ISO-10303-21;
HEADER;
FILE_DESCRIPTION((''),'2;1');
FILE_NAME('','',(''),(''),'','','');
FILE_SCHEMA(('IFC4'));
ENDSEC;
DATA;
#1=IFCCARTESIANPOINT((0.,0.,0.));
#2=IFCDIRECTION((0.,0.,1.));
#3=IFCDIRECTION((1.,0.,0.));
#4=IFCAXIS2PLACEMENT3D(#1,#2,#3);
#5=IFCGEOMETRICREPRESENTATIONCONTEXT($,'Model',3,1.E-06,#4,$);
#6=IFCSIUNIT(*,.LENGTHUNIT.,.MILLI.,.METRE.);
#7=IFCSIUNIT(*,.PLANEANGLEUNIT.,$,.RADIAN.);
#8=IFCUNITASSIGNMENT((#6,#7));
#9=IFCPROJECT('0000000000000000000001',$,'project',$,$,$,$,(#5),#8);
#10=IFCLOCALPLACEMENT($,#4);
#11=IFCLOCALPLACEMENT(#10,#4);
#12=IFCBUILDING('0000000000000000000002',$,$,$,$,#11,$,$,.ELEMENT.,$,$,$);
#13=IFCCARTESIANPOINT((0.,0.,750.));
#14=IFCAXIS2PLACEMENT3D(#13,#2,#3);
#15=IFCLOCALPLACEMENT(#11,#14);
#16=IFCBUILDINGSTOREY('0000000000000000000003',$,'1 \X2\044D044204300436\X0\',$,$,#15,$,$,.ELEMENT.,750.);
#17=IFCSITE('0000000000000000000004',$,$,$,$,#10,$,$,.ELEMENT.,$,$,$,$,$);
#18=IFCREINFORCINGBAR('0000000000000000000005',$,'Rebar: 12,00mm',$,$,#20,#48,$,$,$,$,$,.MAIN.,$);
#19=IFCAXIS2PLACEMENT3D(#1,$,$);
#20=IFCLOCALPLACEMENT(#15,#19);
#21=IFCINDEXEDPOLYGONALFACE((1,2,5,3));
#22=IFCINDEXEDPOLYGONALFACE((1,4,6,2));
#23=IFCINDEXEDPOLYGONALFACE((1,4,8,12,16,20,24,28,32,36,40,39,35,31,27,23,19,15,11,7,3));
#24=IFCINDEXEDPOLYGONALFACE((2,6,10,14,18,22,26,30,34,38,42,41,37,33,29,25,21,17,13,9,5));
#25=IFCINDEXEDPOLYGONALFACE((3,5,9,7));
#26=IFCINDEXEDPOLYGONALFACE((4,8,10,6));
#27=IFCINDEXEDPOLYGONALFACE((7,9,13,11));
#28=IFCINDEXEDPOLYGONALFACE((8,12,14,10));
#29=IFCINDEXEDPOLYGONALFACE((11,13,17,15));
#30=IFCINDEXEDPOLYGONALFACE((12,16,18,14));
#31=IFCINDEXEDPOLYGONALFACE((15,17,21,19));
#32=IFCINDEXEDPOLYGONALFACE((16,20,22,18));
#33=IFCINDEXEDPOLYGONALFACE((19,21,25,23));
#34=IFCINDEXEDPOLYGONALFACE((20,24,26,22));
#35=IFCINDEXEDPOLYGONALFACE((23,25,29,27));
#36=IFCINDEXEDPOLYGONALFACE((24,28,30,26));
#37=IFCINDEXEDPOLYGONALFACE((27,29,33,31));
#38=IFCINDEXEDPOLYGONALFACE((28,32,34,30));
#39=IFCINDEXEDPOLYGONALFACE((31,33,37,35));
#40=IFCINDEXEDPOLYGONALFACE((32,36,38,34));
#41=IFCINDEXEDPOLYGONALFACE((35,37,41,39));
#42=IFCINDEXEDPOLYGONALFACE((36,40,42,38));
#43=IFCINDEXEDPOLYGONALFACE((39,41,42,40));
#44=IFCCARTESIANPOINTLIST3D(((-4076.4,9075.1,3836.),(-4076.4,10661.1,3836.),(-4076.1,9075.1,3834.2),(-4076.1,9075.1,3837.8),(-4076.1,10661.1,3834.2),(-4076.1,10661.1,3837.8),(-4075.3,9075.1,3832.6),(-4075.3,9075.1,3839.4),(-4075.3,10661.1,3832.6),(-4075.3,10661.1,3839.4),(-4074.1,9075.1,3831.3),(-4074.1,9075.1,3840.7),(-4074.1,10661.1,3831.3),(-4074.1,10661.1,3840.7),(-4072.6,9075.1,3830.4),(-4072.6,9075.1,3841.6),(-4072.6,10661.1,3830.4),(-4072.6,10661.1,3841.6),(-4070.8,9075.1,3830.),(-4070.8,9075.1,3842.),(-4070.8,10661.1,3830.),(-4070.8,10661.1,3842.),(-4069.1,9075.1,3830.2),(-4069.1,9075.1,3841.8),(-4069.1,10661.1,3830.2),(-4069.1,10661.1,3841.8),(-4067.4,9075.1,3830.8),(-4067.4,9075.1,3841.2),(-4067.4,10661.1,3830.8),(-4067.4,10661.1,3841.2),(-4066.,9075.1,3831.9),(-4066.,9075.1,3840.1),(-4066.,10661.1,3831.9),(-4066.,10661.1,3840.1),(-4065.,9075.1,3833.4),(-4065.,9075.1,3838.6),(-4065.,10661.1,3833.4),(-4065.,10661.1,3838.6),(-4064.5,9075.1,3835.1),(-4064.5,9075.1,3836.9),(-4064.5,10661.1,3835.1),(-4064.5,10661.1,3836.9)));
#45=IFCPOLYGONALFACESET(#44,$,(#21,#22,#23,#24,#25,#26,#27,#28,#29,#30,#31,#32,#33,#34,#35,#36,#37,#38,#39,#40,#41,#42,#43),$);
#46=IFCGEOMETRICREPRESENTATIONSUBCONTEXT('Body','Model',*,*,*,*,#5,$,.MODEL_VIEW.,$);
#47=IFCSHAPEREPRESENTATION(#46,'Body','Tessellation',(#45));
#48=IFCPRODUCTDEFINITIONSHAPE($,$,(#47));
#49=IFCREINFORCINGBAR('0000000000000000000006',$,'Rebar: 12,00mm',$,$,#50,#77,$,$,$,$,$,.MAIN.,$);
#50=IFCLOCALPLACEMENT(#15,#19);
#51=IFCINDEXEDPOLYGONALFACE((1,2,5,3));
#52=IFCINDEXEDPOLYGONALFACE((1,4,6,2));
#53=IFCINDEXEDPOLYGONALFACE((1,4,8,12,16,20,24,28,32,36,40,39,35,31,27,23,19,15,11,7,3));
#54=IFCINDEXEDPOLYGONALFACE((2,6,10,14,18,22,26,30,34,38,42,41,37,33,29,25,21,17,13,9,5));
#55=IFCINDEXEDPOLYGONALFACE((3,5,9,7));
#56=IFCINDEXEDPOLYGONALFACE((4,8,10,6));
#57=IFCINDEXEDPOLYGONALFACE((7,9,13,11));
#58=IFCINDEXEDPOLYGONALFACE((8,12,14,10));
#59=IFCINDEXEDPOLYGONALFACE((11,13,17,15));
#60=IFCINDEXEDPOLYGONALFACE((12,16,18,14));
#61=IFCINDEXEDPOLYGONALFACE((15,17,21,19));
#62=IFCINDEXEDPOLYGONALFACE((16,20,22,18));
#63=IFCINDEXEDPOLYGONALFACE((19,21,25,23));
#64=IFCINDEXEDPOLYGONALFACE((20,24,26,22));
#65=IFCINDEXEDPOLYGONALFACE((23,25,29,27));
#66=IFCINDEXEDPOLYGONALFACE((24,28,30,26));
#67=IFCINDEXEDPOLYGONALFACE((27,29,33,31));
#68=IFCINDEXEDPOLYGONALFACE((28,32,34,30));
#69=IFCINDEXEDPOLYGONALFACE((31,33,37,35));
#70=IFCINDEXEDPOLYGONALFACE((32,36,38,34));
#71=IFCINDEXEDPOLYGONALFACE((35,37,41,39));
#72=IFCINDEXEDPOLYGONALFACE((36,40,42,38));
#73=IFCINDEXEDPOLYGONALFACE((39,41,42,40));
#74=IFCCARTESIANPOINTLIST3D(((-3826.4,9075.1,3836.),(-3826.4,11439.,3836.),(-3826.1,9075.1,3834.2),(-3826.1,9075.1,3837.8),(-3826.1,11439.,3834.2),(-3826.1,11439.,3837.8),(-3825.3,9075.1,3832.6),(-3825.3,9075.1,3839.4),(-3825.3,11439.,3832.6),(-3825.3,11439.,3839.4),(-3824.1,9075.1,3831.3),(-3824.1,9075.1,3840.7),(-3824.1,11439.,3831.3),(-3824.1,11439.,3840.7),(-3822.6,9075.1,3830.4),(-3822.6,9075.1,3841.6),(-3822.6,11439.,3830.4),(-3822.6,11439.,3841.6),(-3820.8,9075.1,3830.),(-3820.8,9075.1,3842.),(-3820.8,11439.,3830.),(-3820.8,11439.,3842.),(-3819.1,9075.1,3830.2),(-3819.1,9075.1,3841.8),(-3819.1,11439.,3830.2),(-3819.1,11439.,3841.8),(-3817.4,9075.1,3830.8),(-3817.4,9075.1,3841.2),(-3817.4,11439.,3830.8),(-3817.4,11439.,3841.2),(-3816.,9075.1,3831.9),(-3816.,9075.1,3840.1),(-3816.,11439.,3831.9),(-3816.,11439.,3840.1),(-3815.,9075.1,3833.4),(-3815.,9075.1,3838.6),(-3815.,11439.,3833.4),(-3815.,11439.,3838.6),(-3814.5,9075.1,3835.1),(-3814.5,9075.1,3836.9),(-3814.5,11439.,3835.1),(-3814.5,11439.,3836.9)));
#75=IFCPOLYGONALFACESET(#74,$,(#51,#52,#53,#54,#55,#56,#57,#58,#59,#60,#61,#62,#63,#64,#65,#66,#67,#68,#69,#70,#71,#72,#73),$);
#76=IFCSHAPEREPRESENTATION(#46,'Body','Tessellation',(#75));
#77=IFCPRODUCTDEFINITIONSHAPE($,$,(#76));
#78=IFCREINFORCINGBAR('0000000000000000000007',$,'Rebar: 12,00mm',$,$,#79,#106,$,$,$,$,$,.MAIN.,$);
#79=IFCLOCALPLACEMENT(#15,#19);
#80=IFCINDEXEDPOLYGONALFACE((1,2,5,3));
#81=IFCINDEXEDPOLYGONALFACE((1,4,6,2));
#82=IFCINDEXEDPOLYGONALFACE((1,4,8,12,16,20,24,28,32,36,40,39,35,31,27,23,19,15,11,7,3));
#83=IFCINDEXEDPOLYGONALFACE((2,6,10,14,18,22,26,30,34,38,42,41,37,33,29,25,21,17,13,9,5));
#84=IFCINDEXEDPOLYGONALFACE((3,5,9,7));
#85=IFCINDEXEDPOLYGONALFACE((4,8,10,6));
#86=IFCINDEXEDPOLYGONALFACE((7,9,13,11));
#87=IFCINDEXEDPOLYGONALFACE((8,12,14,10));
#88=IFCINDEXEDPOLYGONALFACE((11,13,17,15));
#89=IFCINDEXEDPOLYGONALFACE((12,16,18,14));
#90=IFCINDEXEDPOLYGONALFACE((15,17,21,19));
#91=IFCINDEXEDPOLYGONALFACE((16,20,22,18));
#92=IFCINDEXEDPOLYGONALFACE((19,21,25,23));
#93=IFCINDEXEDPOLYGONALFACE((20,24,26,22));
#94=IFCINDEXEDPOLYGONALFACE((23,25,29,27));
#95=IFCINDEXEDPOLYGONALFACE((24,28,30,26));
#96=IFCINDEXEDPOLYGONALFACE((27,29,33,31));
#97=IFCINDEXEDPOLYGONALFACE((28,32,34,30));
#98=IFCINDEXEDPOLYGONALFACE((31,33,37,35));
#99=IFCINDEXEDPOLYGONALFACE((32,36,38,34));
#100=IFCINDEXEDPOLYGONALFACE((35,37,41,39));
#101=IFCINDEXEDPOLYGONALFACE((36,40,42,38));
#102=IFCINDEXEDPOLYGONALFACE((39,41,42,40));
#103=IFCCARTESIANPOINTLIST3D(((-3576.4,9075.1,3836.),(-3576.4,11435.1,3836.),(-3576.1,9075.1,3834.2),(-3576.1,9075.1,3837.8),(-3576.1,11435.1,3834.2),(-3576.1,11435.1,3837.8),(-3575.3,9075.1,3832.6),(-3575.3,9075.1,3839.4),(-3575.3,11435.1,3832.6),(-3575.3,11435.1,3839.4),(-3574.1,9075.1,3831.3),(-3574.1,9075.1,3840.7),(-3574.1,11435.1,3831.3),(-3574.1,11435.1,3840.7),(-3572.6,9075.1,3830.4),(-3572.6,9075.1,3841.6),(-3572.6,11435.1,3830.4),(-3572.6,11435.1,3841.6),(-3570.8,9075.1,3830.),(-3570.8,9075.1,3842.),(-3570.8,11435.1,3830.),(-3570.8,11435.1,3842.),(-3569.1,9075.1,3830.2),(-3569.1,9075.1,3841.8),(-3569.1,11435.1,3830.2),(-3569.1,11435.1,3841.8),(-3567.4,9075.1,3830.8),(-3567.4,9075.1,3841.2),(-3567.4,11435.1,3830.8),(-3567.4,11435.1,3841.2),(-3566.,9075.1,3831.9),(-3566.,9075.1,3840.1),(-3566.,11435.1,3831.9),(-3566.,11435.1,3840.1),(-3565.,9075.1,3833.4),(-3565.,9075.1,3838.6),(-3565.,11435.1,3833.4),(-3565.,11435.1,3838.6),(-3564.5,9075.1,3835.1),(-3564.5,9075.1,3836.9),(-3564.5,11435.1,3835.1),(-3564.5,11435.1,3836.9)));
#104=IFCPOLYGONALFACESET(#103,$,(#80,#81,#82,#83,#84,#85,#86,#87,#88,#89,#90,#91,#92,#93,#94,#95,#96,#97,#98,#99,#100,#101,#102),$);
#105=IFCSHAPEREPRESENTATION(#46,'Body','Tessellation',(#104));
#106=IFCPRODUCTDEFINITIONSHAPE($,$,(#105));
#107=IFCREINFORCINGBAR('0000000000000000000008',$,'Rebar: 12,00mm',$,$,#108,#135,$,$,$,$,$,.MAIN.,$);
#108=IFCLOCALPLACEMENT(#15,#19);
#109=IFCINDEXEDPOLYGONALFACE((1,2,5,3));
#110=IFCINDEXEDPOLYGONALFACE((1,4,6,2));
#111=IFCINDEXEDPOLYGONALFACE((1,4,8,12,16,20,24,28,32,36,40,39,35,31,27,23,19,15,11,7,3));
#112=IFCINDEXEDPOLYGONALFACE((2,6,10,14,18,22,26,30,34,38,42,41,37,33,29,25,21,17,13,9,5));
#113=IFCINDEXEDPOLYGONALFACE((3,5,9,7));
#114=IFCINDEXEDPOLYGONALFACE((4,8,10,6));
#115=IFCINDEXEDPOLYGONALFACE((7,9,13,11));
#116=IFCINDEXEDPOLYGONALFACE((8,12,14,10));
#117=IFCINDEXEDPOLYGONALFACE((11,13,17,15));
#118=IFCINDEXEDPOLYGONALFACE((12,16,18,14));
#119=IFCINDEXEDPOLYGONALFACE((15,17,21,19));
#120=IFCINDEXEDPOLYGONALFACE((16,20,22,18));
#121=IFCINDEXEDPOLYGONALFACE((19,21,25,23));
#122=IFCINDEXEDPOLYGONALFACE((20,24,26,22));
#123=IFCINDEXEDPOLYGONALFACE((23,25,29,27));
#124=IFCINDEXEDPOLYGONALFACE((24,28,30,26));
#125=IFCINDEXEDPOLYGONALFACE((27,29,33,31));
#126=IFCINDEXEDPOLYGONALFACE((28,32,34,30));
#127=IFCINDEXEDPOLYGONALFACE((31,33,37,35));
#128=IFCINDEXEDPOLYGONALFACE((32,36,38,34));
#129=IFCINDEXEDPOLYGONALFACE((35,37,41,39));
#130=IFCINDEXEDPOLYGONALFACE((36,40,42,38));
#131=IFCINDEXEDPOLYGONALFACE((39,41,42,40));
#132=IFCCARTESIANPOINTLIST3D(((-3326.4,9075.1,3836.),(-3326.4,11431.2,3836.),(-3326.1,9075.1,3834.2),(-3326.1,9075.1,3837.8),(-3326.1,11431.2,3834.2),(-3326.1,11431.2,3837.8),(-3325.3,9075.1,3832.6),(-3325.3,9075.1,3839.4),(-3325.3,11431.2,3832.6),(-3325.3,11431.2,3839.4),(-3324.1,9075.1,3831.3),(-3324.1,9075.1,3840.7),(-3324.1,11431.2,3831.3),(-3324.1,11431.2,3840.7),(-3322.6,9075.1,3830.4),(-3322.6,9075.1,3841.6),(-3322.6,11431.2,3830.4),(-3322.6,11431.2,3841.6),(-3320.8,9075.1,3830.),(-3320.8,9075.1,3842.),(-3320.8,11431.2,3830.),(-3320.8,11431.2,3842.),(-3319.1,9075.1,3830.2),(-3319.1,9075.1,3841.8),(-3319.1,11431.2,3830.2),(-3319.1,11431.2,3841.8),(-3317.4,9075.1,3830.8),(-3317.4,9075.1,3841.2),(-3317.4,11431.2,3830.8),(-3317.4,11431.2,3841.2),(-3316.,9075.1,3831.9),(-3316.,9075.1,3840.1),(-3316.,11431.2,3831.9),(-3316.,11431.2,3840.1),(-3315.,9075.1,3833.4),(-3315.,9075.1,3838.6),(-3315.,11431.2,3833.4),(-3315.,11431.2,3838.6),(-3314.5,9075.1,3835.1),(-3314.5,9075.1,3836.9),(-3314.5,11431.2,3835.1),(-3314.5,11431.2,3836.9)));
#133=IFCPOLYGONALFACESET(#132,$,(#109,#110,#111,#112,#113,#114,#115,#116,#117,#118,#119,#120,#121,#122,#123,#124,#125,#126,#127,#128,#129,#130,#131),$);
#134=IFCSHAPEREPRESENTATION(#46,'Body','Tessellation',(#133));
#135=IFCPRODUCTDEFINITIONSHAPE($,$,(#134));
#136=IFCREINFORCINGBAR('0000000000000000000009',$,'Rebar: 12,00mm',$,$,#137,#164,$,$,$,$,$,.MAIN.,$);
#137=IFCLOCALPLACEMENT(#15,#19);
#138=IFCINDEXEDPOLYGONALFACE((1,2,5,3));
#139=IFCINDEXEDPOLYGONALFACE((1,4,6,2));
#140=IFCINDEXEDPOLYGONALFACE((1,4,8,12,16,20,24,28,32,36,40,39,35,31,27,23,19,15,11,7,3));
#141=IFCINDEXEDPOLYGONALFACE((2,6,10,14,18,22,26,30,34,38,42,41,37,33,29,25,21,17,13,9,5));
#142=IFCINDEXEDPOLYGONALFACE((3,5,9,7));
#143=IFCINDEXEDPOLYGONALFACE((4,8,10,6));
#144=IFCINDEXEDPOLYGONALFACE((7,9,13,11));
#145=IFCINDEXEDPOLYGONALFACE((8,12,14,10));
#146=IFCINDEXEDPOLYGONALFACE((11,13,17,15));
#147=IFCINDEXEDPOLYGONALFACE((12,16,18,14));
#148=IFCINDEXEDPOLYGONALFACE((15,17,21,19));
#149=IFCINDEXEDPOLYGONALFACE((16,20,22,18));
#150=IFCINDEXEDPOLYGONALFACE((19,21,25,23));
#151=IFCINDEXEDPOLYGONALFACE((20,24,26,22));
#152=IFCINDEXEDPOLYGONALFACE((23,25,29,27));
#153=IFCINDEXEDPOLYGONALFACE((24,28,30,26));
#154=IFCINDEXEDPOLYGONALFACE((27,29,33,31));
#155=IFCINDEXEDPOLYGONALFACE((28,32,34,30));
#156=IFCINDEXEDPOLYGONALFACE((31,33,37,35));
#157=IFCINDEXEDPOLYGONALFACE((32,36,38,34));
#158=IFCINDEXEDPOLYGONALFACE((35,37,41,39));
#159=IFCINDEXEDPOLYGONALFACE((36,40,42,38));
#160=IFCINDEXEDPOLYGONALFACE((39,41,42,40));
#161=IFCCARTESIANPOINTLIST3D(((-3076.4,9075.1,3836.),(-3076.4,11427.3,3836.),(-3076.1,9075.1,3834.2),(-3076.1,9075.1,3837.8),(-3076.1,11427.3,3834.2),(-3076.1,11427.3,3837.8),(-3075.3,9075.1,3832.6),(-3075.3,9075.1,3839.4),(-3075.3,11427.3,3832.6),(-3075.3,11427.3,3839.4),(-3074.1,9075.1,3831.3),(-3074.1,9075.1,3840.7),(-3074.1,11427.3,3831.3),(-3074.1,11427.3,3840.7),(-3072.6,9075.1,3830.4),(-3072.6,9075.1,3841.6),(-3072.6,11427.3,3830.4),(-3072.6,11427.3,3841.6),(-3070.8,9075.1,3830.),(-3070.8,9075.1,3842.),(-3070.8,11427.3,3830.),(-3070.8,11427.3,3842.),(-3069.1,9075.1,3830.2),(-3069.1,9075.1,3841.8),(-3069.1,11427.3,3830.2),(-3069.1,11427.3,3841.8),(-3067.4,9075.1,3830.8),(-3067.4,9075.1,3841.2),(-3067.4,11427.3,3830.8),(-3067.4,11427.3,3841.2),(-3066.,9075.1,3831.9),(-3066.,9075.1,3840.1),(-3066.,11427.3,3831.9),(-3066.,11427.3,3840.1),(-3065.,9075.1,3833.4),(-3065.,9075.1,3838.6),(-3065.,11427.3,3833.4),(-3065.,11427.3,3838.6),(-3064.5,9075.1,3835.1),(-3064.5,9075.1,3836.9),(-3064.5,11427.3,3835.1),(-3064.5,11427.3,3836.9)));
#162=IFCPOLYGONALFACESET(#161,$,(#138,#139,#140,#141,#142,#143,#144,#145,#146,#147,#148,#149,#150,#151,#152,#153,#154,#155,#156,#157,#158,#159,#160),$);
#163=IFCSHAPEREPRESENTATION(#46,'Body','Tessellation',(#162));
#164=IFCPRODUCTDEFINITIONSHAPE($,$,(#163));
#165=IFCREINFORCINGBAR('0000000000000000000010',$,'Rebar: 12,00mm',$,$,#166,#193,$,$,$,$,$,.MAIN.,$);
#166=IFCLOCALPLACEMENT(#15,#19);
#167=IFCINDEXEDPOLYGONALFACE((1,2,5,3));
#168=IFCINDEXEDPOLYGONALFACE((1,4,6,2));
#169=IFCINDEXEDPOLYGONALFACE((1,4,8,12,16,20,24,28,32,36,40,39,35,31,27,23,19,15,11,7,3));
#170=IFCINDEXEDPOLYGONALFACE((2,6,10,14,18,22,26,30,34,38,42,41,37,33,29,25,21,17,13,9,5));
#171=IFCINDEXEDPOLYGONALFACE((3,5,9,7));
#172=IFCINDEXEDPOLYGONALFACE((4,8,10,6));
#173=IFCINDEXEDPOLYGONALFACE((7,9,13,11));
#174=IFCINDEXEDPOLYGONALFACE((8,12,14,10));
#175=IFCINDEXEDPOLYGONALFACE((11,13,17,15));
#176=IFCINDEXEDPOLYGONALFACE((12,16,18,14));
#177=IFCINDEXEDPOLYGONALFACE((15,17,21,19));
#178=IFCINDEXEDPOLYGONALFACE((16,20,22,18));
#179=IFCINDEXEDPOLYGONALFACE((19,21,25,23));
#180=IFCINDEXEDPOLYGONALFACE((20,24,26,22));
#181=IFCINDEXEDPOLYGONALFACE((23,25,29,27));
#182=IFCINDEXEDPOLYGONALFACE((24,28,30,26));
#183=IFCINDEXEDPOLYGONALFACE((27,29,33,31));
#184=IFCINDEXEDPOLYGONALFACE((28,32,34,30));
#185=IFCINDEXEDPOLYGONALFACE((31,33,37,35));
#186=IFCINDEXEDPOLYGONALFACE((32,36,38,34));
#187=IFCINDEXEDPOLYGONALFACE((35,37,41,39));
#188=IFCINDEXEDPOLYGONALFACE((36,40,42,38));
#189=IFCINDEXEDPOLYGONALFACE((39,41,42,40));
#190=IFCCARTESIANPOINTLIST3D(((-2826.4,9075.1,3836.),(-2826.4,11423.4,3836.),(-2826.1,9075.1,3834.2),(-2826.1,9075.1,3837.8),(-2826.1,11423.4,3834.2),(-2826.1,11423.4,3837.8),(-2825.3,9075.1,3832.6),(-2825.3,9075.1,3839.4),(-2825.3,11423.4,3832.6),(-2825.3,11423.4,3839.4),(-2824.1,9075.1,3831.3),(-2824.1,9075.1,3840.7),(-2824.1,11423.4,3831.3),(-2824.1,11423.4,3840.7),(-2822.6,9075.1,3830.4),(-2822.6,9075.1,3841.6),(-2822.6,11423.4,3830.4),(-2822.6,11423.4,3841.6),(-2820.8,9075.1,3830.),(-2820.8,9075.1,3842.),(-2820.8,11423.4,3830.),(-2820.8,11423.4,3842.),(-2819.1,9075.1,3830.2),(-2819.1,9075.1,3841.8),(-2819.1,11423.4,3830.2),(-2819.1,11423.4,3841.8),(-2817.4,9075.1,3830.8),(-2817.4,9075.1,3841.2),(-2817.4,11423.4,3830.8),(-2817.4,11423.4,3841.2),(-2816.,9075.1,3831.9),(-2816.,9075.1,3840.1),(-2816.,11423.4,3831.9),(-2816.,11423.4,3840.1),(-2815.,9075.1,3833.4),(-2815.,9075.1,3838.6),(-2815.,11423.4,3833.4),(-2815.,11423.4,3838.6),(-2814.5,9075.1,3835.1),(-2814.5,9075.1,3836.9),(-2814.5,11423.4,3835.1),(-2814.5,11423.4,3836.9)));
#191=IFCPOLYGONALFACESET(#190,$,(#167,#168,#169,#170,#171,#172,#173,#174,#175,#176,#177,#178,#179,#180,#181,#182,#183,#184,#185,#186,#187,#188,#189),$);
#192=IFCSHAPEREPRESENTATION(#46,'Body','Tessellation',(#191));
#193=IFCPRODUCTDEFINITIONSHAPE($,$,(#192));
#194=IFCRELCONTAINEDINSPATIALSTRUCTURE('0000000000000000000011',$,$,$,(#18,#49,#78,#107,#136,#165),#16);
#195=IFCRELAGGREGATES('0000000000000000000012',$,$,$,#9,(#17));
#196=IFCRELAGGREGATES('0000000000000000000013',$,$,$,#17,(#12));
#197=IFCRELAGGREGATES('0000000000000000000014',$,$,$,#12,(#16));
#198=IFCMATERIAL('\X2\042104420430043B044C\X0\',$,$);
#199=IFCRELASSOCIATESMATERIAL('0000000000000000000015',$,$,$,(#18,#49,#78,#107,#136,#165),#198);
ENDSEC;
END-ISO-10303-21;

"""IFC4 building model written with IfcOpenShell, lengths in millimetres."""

from ifc_helpers import new_model, entity, si_unit, frame, origin_with_axes, place, context, subcontext, project, spatial, source, transform, mapped, material, element, save


model = new_model("IFC4")

# Units and contexts
model_context = context("Model", 3, precision=1e-06, world=origin_with_axes())
body_context = subcontext(model_context, "Body", "Model", "MODEL_VIEW")
ifc_project = project(units=[si_unit("LENGTHUNIT", "METRE", prefix="MILLI"), si_unit("PLANEANGLEUNIT", "RADIAN")], contexts=[model_context])

# Site, building, storey
site_placement = place(None, origin_with_axes())
site = spatial("IfcSite", under=ifc_project, at=site_placement, CompositionType="ELEMENT")
building_placement = place(site_placement, origin_with_axes())
building = spatial("IfcBuilding", under=site, at=building_placement, CompositionType="ELEMENT")
storey_placement = place(building_placement, frame((0.0, 0.0, 750.0), z_axis=(0.0, 0.0, 1.0), x_axis=(1.0, 0.0, 0.0)))
storey = spatial("IfcBuildingStorey", under=building, at=storey_placement, Name="1 этаж", CompositionType="ELEMENT", Elevation=750.0)

# Reinforcing bars
ifc_material = material(Name="Сталь")
shared_shape_1 = source(origin_with_axes(), body_context, "Body", "AdvancedSweptSolid", [
    entity("IfcSweptDiskSolid", entity("IfcIndexedPolyCurve", entity("IfcCartesianPointList3D", [[0.0, 0.0, 0.0], [1585.9, 0.0, 0.0]]), [entity("IfcLineIndex", [1, 2])]), 6.0),
])
reinforcing_bar_1_placement = place(storey_placement, origin_with_axes())
element("IfcReinforcingBar", 1, at=reinforcing_bar_1_placement, inside=storey, material=ifc_material, Name="Rebar: 12,00mm", PredefinedType="MAIN", context=body_context, shape_type="MappedRepresentation", body=[
    mapped(shared_shape_1, transform((-4070.4, 9075.1, 3836.0), x_axis=(0.0, 1.0, 0.0), y_axis=(-1.0, 0.0, 0.0), z_axis=(0.0, 0.0, 1.0), scale=1.0)),
])
shared_shape_2 = source(origin_with_axes(), body_context, "Body", "AdvancedSweptSolid", [
    entity("IfcSweptDiskSolid", entity("IfcIndexedPolyCurve", entity("IfcCartesianPointList3D", [[0.0, 0.0, 0.0], [2363.8, 0.0, 0.0]]), [entity("IfcLineIndex", [1, 2])]), 6.0),
])
reinforcing_bar_2_placement = place(storey_placement, origin_with_axes())
element("IfcReinforcingBar", 2, at=reinforcing_bar_2_placement, inside=storey, material=ifc_material, Name="Rebar: 12,00mm", PredefinedType="MAIN", context=body_context, shape_type="MappedRepresentation", body=[
    mapped(shared_shape_2, transform((-3820.4, 9075.1, 3836.0), x_axis=(0.0, 1.0, 0.0), y_axis=(-1.0, 0.0, 0.0), z_axis=(0.0, 0.0, 1.0), scale=1.0)),
])
shared_shape_3 = source(origin_with_axes(), body_context, "Body", "AdvancedSweptSolid", [
    entity("IfcSweptDiskSolid", entity("IfcIndexedPolyCurve", entity("IfcCartesianPointList3D", [[0.0, 0.0, 0.0], [2359.9, 0.0, 0.0]]), [entity("IfcLineIndex", [1, 2])]), 6.0),
])
reinforcing_bar_3_placement = place(storey_placement, origin_with_axes())
element("IfcReinforcingBar", 3, at=reinforcing_bar_3_placement, inside=storey, material=ifc_material, Name="Rebar: 12,00mm", PredefinedType="MAIN", context=body_context, shape_type="MappedRepresentation", body=[
    mapped(shared_shape_3, transform((-3570.4, 9075.1, 3836.0), x_axis=(0.0, 1.0, 0.0), y_axis=(-1.0, 0.0, 0.0), z_axis=(0.0, 0.0, 1.0), scale=1.0)),
])
shared_shape_4 = source(origin_with_axes(), body_context, "Body", "AdvancedSweptSolid", [
    entity("IfcSweptDiskSolid", entity("IfcIndexedPolyCurve", entity("IfcCartesianPointList3D", [[0.0, 0.0, 0.0], [2356.1, 0.0, 0.0]]), [entity("IfcLineIndex", [1, 2])]), 6.0),
])
reinforcing_bar_4_placement = place(storey_placement, origin_with_axes())
element("IfcReinforcingBar", 4, at=reinforcing_bar_4_placement, inside=storey, material=ifc_material, Name="Rebar: 12,00mm", PredefinedType="MAIN", context=body_context, shape_type="MappedRepresentation", body=[
    mapped(shared_shape_4, transform((-3320.4, 9075.1, 3836.0), x_axis=(0.0, 1.0, 0.0), y_axis=(-1.0, 0.0, 0.0), z_axis=(0.0, 0.0, 1.0), scale=1.0)),
])
shared_shape_5 = source(origin_with_axes(), body_context, "Body", "AdvancedSweptSolid", [
    entity("IfcSweptDiskSolid", entity("IfcIndexedPolyCurve", entity("IfcCartesianPointList3D", [[0.0, 0.0, 0.0], [2352.2, 0.0, 0.0]]), [entity("IfcLineIndex", [1, 2])]), 6.0),
])
reinforcing_bar_5_placement = place(storey_placement, origin_with_axes())
element("IfcReinforcingBar", 5, at=reinforcing_bar_5_placement, inside=storey, material=ifc_material, Name="Rebar: 12,00mm", PredefinedType="MAIN", context=body_context, shape_type="MappedRepresentation", body=[
    mapped(shared_shape_5, transform((-3070.4, 9075.1, 3836.0), x_axis=(0.0, 1.0, 0.0), y_axis=(-1.0, 0.0, 0.0), z_axis=(0.0, 0.0, 1.0), scale=1.0)),
])
shared_shape_6 = source(origin_with_axes(), body_context, "Body", "AdvancedSweptSolid", [
    entity("IfcSweptDiskSolid", entity("IfcIndexedPolyCurve", entity("IfcCartesianPointList3D", [[0.0, 0.0, 0.0], [2348.3, 0.0, 0.0]]), [entity("IfcLineIndex", [1, 2])]), 6.0),
])
reinforcing_bar_6_placement = place(storey_placement, origin_with_axes())
element("IfcReinforcingBar", 6, at=reinforcing_bar_6_placement, inside=storey, material=ifc_material, Name="Rebar: 12,00mm", PredefinedType="MAIN", context=body_context, shape_type="MappedRepresentation", body=[
    mapped(shared_shape_6, transform((-2820.4, 9075.1, 3836.0), x_axis=(0.0, 1.0, 0.0), y_axis=(-1.0, 0.0, 0.0), z_axis=(0.0, 0.0, 1.0), scale=1.0)),
])

save(model, "model.ifc")
